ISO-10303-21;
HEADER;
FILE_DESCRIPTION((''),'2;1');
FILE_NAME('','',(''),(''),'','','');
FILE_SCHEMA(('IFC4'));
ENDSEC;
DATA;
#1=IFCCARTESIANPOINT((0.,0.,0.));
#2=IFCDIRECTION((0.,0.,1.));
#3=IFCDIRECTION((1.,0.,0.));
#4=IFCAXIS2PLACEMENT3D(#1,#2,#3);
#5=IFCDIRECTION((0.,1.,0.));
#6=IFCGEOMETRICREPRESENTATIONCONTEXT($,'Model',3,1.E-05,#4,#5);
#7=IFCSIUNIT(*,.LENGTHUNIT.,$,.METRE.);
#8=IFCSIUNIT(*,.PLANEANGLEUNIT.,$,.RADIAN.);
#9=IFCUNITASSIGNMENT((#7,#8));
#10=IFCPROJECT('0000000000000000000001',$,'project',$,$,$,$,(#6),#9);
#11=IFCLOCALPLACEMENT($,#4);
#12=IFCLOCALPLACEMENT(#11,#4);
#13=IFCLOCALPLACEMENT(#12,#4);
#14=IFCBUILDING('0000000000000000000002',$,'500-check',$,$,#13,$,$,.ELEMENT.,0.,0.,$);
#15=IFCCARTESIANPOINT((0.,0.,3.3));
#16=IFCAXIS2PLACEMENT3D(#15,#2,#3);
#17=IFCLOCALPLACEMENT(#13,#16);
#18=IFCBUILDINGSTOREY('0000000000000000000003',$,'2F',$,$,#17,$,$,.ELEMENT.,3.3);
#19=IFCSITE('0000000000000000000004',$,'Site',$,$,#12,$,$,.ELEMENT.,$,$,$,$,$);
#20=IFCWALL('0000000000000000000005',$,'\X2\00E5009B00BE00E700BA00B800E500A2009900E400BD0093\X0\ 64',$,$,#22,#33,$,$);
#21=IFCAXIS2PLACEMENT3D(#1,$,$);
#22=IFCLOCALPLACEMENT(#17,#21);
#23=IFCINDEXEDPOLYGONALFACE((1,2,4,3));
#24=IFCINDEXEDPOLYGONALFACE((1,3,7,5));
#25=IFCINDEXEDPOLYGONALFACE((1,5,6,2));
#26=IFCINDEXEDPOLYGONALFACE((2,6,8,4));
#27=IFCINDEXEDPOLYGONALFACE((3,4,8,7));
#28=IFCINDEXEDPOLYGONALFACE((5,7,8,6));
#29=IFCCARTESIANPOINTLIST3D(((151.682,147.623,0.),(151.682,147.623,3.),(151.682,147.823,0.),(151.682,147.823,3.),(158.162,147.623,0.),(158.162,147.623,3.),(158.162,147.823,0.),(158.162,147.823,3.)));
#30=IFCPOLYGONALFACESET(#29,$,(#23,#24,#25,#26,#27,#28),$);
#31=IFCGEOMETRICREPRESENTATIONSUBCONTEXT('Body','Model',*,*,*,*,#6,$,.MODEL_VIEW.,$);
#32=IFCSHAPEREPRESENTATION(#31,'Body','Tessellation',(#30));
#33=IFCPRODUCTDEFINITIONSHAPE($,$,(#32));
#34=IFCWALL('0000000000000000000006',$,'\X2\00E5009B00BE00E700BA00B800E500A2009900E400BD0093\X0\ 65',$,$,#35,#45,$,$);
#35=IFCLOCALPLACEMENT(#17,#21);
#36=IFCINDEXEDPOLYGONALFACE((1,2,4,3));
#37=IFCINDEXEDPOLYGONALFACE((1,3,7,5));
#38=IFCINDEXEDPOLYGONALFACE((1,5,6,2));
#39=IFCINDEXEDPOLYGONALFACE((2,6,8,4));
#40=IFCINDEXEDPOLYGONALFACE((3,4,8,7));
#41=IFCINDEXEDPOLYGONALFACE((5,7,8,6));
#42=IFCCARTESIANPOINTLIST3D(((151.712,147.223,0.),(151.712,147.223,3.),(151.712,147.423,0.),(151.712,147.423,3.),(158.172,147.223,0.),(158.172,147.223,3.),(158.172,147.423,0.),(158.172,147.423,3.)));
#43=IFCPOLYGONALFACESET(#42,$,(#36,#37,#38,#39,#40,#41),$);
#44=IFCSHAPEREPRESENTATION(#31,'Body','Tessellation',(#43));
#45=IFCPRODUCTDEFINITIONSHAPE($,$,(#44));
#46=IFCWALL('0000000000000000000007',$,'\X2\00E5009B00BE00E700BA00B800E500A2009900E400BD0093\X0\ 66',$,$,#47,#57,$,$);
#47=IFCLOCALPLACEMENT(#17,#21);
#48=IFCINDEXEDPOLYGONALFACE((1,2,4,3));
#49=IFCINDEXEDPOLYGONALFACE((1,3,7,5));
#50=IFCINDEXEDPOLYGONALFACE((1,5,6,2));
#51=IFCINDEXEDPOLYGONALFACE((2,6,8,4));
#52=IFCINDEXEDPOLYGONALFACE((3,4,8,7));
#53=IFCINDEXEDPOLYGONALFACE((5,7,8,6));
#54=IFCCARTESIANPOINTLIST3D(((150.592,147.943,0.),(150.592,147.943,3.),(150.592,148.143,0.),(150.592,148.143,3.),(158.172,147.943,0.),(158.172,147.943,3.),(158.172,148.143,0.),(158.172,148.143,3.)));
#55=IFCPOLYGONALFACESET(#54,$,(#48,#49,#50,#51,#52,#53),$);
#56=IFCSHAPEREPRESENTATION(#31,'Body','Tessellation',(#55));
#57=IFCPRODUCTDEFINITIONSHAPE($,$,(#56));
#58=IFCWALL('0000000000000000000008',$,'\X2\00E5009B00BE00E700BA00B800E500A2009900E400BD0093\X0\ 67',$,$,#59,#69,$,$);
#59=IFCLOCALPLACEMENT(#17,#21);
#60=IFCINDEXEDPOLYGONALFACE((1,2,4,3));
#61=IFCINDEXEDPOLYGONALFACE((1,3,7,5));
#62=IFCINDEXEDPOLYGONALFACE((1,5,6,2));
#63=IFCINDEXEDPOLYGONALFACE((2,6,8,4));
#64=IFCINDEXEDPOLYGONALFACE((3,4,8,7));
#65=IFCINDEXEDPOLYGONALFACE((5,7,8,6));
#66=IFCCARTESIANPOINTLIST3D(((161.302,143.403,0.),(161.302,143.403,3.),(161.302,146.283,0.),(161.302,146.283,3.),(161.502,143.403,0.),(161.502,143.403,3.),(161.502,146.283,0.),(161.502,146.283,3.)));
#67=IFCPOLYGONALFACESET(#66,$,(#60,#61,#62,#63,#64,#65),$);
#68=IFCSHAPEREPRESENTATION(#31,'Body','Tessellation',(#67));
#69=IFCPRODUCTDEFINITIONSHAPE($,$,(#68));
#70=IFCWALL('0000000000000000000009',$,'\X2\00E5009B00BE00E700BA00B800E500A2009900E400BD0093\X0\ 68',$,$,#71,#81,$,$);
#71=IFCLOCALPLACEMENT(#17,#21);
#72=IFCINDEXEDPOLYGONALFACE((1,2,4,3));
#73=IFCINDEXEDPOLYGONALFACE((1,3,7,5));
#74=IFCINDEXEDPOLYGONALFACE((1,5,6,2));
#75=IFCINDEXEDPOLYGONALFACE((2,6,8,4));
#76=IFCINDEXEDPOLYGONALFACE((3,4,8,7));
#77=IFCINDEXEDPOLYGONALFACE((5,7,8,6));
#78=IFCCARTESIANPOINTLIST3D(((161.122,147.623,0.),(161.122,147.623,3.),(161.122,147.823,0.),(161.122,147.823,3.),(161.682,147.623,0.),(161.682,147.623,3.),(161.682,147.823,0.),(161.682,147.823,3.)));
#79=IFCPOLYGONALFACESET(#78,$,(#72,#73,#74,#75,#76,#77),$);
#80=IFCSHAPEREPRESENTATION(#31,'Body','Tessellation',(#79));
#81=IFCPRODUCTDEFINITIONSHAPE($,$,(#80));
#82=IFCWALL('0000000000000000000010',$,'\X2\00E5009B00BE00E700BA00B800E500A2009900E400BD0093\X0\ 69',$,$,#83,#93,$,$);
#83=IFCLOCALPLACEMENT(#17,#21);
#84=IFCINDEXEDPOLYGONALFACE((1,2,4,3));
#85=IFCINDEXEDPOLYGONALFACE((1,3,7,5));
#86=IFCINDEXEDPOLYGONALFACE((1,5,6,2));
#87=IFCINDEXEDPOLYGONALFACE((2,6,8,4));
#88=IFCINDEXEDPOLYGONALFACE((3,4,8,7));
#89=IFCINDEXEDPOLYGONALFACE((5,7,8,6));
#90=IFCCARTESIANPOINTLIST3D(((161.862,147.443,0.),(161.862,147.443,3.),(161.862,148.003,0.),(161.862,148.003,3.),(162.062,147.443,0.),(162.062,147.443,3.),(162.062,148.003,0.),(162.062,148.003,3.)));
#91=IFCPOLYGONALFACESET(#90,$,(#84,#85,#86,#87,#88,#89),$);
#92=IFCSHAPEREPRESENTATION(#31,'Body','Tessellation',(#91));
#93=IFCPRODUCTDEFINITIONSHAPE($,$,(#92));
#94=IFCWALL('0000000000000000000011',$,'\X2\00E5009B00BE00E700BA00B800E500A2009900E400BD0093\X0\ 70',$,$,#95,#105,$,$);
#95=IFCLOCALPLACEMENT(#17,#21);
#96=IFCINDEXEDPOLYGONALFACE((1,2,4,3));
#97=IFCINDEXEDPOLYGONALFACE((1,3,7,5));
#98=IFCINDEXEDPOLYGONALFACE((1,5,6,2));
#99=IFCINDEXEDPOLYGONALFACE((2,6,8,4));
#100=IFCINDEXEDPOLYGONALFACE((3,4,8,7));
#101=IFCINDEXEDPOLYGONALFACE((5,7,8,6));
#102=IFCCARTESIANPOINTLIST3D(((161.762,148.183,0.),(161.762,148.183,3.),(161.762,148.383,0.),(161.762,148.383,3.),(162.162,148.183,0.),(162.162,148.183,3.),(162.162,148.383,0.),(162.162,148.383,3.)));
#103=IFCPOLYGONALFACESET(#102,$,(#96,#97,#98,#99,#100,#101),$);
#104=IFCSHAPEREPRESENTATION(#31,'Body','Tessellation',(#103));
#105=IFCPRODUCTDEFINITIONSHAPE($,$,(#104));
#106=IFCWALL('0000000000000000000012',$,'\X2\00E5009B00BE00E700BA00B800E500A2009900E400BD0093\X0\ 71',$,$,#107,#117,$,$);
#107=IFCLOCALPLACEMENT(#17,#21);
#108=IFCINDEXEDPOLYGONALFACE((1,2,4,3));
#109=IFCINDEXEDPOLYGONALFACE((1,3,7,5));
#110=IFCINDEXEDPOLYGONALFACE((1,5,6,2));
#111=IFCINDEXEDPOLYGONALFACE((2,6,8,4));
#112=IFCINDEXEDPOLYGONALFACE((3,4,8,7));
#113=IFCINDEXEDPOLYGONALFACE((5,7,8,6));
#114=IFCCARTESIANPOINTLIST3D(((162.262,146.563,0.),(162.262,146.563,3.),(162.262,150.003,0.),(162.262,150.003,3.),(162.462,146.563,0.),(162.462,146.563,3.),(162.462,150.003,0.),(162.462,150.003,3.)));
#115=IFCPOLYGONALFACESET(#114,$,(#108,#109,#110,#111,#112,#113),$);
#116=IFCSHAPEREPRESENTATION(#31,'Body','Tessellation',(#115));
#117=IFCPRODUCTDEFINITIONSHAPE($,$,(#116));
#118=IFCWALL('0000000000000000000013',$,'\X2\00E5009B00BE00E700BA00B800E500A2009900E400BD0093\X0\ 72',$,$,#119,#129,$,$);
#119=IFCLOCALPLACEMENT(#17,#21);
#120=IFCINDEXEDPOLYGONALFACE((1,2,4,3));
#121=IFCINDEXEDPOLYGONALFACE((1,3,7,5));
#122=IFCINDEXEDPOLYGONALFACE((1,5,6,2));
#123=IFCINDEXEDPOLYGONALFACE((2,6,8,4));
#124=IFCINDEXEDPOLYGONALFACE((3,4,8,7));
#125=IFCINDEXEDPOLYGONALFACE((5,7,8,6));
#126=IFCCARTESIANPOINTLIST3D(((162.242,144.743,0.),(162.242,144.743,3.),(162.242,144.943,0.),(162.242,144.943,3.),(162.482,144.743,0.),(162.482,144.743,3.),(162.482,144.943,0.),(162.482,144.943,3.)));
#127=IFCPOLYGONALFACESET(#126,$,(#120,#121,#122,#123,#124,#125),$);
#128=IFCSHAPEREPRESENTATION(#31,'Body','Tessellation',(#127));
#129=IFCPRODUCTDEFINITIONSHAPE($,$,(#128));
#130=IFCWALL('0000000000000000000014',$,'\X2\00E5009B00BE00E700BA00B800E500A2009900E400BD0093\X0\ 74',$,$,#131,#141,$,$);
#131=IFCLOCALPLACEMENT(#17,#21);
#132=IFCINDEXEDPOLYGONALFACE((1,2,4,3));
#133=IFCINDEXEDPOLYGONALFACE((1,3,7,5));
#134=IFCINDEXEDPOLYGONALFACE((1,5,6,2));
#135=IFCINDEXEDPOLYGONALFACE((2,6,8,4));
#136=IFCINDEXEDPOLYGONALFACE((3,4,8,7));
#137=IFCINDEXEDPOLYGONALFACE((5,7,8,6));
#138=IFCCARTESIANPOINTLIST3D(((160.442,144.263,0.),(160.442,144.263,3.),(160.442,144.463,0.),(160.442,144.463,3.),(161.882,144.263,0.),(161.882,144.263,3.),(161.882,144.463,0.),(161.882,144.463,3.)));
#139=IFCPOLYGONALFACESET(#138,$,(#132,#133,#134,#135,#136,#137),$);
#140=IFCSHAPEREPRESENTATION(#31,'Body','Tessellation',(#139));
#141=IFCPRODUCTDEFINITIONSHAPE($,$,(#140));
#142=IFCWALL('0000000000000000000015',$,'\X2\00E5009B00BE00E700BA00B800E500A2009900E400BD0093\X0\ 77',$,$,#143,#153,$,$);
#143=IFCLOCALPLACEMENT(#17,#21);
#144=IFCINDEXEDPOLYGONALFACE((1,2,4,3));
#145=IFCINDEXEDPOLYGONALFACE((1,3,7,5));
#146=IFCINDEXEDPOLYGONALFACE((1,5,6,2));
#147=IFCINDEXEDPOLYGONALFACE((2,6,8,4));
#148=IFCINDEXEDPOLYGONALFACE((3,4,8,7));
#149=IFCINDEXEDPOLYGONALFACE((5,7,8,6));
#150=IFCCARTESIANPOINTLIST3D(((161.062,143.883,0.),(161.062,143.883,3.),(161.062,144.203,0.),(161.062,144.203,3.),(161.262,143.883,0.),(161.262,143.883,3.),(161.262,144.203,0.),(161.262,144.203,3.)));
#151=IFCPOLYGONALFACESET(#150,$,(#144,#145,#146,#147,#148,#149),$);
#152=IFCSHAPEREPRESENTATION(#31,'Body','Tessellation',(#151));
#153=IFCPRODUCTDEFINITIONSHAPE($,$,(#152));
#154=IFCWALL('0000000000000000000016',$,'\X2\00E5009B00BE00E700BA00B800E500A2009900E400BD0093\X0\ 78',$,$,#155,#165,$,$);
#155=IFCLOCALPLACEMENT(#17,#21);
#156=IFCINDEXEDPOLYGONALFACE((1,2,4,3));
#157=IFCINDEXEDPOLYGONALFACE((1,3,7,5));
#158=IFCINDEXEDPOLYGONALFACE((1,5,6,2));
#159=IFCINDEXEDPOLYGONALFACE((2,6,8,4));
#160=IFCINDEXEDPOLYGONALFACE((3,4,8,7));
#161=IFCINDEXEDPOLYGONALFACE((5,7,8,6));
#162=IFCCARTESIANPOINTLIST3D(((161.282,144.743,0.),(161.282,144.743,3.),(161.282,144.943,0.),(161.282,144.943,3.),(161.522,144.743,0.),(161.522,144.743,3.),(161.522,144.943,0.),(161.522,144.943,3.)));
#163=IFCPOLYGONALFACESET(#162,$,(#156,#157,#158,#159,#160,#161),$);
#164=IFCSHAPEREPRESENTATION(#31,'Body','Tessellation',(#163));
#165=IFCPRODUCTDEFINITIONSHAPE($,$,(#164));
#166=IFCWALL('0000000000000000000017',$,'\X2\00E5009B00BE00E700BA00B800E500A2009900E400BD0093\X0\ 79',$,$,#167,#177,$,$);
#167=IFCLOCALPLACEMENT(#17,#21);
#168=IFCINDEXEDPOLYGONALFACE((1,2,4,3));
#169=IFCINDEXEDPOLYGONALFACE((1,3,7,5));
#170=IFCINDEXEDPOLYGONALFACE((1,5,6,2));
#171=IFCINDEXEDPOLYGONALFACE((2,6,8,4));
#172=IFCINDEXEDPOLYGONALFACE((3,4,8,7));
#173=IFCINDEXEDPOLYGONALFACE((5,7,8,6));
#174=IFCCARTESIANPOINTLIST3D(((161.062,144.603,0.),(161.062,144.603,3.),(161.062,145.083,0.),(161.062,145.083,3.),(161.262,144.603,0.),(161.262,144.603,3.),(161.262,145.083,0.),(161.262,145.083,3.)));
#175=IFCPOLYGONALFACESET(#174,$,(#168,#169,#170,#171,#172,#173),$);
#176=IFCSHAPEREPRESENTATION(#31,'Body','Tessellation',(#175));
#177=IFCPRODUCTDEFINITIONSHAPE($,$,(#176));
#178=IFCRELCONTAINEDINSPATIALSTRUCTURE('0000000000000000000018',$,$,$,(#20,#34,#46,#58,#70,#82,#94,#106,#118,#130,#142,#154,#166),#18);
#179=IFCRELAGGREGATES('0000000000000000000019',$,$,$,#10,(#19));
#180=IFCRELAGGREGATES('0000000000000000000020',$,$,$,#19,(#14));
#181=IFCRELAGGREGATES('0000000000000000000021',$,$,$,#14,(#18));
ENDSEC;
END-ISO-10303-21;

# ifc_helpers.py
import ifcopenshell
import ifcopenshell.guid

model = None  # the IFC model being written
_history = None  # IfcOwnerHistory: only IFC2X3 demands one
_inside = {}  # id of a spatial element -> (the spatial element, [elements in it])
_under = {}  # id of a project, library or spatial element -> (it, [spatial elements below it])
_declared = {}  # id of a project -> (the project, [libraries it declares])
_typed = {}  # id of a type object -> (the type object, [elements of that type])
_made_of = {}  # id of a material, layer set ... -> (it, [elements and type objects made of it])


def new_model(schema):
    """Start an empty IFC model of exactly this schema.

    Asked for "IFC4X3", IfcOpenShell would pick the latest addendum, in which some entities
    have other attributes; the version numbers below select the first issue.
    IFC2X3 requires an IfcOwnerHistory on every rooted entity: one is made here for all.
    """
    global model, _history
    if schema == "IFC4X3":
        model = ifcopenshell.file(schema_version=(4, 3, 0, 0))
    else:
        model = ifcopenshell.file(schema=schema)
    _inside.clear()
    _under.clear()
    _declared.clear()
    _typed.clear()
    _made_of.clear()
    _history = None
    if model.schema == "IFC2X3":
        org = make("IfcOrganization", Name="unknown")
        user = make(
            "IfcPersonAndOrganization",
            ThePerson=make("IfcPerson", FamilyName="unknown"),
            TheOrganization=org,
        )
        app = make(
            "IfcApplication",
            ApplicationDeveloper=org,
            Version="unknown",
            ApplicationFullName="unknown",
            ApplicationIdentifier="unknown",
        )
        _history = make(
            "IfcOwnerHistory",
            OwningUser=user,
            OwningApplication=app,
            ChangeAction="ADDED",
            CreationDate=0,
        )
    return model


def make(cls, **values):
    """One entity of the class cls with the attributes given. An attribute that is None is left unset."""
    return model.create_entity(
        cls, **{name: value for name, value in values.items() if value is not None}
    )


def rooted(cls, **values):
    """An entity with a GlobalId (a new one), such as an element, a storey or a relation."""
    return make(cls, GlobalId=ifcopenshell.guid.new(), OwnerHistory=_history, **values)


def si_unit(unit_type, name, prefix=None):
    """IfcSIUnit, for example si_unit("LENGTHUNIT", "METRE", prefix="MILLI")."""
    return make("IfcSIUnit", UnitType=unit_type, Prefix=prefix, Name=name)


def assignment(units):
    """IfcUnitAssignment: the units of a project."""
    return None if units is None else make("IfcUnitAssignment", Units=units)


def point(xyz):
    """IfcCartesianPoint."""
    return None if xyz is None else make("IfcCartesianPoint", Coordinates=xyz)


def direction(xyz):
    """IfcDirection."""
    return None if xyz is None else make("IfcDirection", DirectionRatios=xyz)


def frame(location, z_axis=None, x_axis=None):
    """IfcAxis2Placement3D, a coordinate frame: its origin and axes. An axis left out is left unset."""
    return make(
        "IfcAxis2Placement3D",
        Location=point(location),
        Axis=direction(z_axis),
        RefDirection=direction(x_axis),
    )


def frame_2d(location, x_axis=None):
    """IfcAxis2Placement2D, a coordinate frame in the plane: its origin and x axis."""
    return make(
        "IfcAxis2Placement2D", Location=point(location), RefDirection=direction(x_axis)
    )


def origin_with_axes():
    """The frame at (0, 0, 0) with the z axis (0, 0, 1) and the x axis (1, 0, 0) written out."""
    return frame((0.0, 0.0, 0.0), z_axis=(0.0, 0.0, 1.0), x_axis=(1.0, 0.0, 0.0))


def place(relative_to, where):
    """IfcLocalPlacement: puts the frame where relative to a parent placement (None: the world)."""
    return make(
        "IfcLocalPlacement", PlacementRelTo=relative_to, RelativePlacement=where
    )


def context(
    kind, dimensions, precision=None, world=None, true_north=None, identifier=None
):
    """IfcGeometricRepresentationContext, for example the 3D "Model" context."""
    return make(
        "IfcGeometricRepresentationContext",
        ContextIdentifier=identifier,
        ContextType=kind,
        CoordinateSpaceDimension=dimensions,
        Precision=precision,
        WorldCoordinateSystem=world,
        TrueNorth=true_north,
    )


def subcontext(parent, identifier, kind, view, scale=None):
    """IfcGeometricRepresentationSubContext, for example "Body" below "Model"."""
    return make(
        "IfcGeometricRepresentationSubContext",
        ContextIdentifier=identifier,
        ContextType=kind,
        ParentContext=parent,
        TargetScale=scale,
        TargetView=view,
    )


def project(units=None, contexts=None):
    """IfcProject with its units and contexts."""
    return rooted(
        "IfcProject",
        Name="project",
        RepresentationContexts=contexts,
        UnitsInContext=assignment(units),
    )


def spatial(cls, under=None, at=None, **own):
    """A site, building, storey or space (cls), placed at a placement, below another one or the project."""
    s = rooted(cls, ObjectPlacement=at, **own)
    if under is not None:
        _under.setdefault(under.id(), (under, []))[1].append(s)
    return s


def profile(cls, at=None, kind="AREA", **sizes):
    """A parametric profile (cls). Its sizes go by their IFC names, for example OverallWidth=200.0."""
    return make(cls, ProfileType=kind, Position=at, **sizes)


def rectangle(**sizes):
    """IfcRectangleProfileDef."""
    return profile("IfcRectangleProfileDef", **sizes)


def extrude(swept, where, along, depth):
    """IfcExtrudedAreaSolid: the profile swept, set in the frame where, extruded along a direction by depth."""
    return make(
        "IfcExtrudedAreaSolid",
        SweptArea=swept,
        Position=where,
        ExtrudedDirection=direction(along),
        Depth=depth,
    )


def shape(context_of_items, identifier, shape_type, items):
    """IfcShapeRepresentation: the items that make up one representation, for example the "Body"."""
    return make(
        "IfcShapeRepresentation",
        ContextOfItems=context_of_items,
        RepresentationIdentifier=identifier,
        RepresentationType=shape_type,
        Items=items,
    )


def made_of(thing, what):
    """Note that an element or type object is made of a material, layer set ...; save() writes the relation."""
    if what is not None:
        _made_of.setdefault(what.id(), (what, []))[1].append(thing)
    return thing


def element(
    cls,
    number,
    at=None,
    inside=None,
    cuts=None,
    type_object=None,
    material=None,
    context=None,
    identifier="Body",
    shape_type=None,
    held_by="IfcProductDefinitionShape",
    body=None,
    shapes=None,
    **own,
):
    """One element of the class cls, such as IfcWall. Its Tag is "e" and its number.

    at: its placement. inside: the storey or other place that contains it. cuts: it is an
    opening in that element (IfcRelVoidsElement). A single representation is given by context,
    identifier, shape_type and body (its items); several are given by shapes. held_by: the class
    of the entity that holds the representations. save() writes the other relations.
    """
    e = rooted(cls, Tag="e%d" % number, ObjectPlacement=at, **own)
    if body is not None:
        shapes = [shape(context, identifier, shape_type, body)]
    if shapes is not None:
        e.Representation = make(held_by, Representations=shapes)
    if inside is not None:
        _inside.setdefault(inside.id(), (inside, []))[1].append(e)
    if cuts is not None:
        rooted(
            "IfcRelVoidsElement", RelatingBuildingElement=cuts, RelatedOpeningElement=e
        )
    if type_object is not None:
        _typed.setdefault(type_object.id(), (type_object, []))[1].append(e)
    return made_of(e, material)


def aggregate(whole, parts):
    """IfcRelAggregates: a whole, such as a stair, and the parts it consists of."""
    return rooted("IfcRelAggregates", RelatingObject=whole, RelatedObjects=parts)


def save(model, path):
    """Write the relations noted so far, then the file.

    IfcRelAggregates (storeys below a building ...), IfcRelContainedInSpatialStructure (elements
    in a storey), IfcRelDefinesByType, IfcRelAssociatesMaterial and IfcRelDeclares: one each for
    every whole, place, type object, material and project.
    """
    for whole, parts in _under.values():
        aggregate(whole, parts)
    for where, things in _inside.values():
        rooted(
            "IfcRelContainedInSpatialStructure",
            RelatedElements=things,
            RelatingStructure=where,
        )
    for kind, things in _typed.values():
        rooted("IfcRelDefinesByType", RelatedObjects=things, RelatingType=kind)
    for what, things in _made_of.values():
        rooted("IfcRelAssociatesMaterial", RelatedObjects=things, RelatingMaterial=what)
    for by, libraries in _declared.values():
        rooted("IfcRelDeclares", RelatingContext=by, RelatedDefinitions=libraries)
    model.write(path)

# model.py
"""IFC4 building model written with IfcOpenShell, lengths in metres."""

from ifc_helpers import new_model, si_unit, direction, frame, frame_2d, origin_with_axes, place, context, subcontext, project, spatial, rectangle, extrude, element, save


model = new_model("IFC4")

# Units and contexts
model_context = context("Model", 3, precision=1e-05, world=origin_with_axes(), true_north=direction((0.0, 1.0, 0.0)))
body_context = subcontext(model_context, "Body", "Model", "MODEL_VIEW")
ifc_project = project(units=[si_unit("LENGTHUNIT", "METRE"), si_unit("PLANEANGLEUNIT", "RADIAN")], contexts=[model_context])

# Site, building, storey
placement = place(None, origin_with_axes())
site_placement = place(placement, origin_with_axes())
site = spatial("IfcSite", under=ifc_project, at=site_placement, Name="Site", CompositionType="ELEMENT")
building_placement = place(site_placement, origin_with_axes())
building = spatial("IfcBuilding", under=site, at=building_placement, Name="500-check", CompositionType="ELEMENT", ElevationOfRefHeight=0.0, ElevationOfTerrain=0.0)
storey_placement = place(building_placement, frame((0.0, 0.0, 3.3), z_axis=(0.0, 0.0, 1.0), x_axis=(1.0, 0.0, 0.0)))
storey = spatial("IfcBuildingStorey", under=building, at=storey_placement, Name="2F", CompositionType="ELEMENT", Elevation=3.3)

# Walls
wall_1_placement = place(storey_placement, frame((154.922, 147.723, 0.0), z_axis=(0.0, 0.0, 1.0), x_axis=(1.0, 0.0, 0.0)))
element("IfcWall", 1, at=wall_1_placement, inside=storey, Name="å\u009b¾çº¸å¢\u0099ä½\u0093 64", context=body_context, shape_type="SweptSolid", body=[
    extrude(rectangle(XDim=6.48, YDim=0.2, at=frame_2d((0.0, 0.0), x_axis=(1.0, 0.0, 0.0))), frame((0.0, 0.0, 0.0), z_axis=(0.0, 0.0, 1.0)), (0.0, 0.0, 1.0), 3.0),
])
wall_2_placement = place(storey_placement, frame((154.942, 147.323, 0.0), z_axis=(0.0, 0.0, 1.0), x_axis=(1.0, 0.0, 0.0)))
element("IfcWall", 2, at=wall_2_placement, inside=storey, Name="å\u009b¾çº¸å¢\u0099ä½\u0093 65", context=body_context, shape_type="SweptSolid", body=[
    extrude(rectangle(XDim=6.46, YDim=0.2, at=frame_2d((0.0, 0.0), x_axis=(1.0, 0.0, 0.0))), frame((0.0, 0.0, 0.0), z_axis=(0.0, 0.0, 1.0)), (0.0, 0.0, 1.0), 3.0),
])
wall_3_placement = place(storey_placement, frame((154.382, 148.043, 0.0), z_axis=(0.0, 0.0, 1.0), x_axis=(1.0, 0.0, 0.0)))
element("IfcWall", 3, at=wall_3_placement, inside=storey, Name="å\u009b¾çº¸å¢\u0099ä½\u0093 66", context=body_context, shape_type="SweptSolid", body=[
    extrude(rectangle(XDim=7.58, YDim=0.2, at=frame_2d((0.0, 0.0), x_axis=(1.0, 0.0, 0.0))), frame((0.0, 0.0, 0.0), z_axis=(0.0, 0.0, 1.0)), (0.0, 0.0, 1.0), 3.0),
])
wall_4_placement = place(storey_placement, frame((161.402, 144.843, 0.0), z_axis=(0.0, 0.0, 1.0), x_axis=(0.0, 1.0, 0.0)))
element("IfcWall", 4, at=wall_4_placement, inside=storey, Name="å\u009b¾çº¸å¢\u0099ä½\u0093 67", context=body_context, shape_type="SweptSolid", body=[
    extrude(rectangle(XDim=2.88, YDim=0.2, at=frame_2d((0.0, 0.0), x_axis=(1.0, 0.0, 0.0))), frame((0.0, 0.0, 0.0), z_axis=(0.0, 0.0, 1.0)), (0.0, 0.0, 1.0), 3.0),
])
for number, where, z_axis, x_axis, name in (
    (5, (161.402, 147.723, 0.0), (0.0, 0.0, 1.0), (1.0, 0.0, 0.0), "å\u009b¾çº¸å¢\u0099ä½\u0093 68"),
    (6, (161.962, 147.723, 0.0), (0.0, 0.0, 1.0), (0.0, 1.0, 0.0), "å\u009b¾çº¸å¢\u0099ä½\u0093 69"),
):
    element("IfcWall", number, at=place(storey_placement, frame(where, z_axis=z_axis, x_axis=x_axis)), inside=storey, Name=name, context=body_context, shape_type="SweptSolid", body=[
        extrude(rectangle(XDim=0.56, YDim=0.2, at=frame_2d((0.0, 0.0), x_axis=(1.0, 0.0, 0.0))), frame((0.0, 0.0, 0.0), z_axis=(0.0, 0.0, 1.0)), (0.0, 0.0, 1.0), 3.0),
    ])
wall_5_placement = place(storey_placement, frame((161.962, 148.283, 0.0), z_axis=(0.0, 0.0, 1.0), x_axis=(1.0, 0.0, 0.0)))
element("IfcWall", 7, at=wall_5_placement, inside=storey, Name="å\u009b¾çº¸å¢\u0099ä½\u0093 70", context=body_context, shape_type="SweptSolid", body=[
    extrude(rectangle(XDim=0.4, YDim=0.2, at=frame_2d((0.0, 0.0), x_axis=(1.0, 0.0, 0.0))), frame((0.0, 0.0, 0.0), z_axis=(0.0, 0.0, 1.0)), (0.0, 0.0, 1.0), 3.0),
])
wall_6_placement = place(storey_placement, frame((162.362, 148.283, 0.0), z_axis=(0.0, 0.0, 1.0), x_axis=(0.0, -1.0, 0.0)))
element("IfcWall", 8, at=wall_6_placement, inside=storey, Name="å\u009b¾çº¸å¢\u0099ä½\u0093 71", context=body_context, shape_type="SweptSolid", body=[
    extrude(rectangle(XDim=3.44, YDim=0.2, at=frame_2d((0.0, 0.0), x_axis=(1.0, 0.0, 0.0))), frame((0.0, 0.0, 0.0), z_axis=(0.0, 0.0, 1.0)), (0.0, 0.0, 1.0), 3.0),
])
wall_7_placement = place(storey_placement, frame((162.362, 144.843, 0.0), z_axis=(0.0, 0.0, 1.0), x_axis=(1.0, 0.0, 0.0)))
element("IfcWall", 9, at=wall_7_placement, inside=storey, Name="å\u009b¾çº¸å¢\u0099ä½\u0093 72", context=body_context, shape_type="SweptSolid", body=[
    extrude(rectangle(XDim=0.24, YDim=0.2, at=frame_2d((0.0, 0.0), x_axis=(1.0, 0.0, 0.0))), frame((0.0, 0.0, 0.0), z_axis=(0.0, 0.0, 1.0)), (0.0, 0.0, 1.0), 3.0),
])
wall_8_placement = place(storey_placement, frame((161.162, 144.363, 0.0), z_axis=(0.0, 0.0, 1.0), x_axis=(1.0, 0.0, 0.0)))
element("IfcWall", 10, at=wall_8_placement, inside=storey, Name="å\u009b¾çº¸å¢\u0099ä½\u0093 74", context=body_context, shape_type="SweptSolid", body=[
    extrude(rectangle(XDim=1.44, YDim=0.2, at=frame_2d((0.0, 0.0), x_axis=(1.0, 0.0, 0.0))), frame((0.0, 0.0, 0.0), z_axis=(0.0, 0.0, 1.0)), (0.0, 0.0, 1.0), 3.0),
])
wall_9_placement = place(storey_placement, frame((161.162, 144.043, 0.0), z_axis=(0.0, 0.0, 1.0), x_axis=(0.0, 1.0, 0.0)))
element("IfcWall", 11, at=wall_9_placement, inside=storey, Name="å\u009b¾çº¸å¢\u0099ä½\u0093 77", context=body_context, shape_type="SweptSolid", body=[
    extrude(rectangle(XDim=0.32, YDim=0.2, at=frame_2d((0.0, 0.0), x_axis=(1.0, 0.0, 0.0))), frame((0.0, 0.0, 0.0), z_axis=(0.0, 0.0, 1.0)), (0.0, 0.0, 1.0), 3.0),
])
wall_10_placement = place(storey_placement, frame((161.402, 144.843, 0.0), z_axis=(0.0, 0.0, 1.0), x_axis=(-1.0, 0.0, 0.0)))
element("IfcWall", 12, at=wall_10_placement, inside=storey, Name="å\u009b¾çº¸å¢\u0099ä½\u0093 78", context=body_context, shape_type="SweptSolid", body=[
    extrude(rectangle(XDim=0.24, YDim=0.2, at=frame_2d((0.0, 0.0), x_axis=(1.0, 0.0, 0.0))), frame((0.0, 0.0, 0.0), z_axis=(0.0, 0.0, 1.0)), (0.0, 0.0, 1.0), 3.0),
])
wall_11_placement = place(storey_placement, frame((161.162, 144.843, 0.0), z_axis=(0.0, 0.0, 1.0), x_axis=(0.0, -1.0, 0.0)))
element("IfcWall", 13, at=wall_11_placement, inside=storey, Name="å\u009b¾çº¸å¢\u0099ä½\u0093 79", context=body_context, shape_type="SweptSolid", body=[
    extrude(rectangle(XDim=0.48, YDim=0.2, at=frame_2d((0.0, 0.0), x_axis=(1.0, 0.0, 0.0))), frame((0.0, 0.0, 0.0), z_axis=(0.0, 0.0, 1.0)), (0.0, 0.0, 1.0), 3.0),
])

save(model, "model.ifc")
